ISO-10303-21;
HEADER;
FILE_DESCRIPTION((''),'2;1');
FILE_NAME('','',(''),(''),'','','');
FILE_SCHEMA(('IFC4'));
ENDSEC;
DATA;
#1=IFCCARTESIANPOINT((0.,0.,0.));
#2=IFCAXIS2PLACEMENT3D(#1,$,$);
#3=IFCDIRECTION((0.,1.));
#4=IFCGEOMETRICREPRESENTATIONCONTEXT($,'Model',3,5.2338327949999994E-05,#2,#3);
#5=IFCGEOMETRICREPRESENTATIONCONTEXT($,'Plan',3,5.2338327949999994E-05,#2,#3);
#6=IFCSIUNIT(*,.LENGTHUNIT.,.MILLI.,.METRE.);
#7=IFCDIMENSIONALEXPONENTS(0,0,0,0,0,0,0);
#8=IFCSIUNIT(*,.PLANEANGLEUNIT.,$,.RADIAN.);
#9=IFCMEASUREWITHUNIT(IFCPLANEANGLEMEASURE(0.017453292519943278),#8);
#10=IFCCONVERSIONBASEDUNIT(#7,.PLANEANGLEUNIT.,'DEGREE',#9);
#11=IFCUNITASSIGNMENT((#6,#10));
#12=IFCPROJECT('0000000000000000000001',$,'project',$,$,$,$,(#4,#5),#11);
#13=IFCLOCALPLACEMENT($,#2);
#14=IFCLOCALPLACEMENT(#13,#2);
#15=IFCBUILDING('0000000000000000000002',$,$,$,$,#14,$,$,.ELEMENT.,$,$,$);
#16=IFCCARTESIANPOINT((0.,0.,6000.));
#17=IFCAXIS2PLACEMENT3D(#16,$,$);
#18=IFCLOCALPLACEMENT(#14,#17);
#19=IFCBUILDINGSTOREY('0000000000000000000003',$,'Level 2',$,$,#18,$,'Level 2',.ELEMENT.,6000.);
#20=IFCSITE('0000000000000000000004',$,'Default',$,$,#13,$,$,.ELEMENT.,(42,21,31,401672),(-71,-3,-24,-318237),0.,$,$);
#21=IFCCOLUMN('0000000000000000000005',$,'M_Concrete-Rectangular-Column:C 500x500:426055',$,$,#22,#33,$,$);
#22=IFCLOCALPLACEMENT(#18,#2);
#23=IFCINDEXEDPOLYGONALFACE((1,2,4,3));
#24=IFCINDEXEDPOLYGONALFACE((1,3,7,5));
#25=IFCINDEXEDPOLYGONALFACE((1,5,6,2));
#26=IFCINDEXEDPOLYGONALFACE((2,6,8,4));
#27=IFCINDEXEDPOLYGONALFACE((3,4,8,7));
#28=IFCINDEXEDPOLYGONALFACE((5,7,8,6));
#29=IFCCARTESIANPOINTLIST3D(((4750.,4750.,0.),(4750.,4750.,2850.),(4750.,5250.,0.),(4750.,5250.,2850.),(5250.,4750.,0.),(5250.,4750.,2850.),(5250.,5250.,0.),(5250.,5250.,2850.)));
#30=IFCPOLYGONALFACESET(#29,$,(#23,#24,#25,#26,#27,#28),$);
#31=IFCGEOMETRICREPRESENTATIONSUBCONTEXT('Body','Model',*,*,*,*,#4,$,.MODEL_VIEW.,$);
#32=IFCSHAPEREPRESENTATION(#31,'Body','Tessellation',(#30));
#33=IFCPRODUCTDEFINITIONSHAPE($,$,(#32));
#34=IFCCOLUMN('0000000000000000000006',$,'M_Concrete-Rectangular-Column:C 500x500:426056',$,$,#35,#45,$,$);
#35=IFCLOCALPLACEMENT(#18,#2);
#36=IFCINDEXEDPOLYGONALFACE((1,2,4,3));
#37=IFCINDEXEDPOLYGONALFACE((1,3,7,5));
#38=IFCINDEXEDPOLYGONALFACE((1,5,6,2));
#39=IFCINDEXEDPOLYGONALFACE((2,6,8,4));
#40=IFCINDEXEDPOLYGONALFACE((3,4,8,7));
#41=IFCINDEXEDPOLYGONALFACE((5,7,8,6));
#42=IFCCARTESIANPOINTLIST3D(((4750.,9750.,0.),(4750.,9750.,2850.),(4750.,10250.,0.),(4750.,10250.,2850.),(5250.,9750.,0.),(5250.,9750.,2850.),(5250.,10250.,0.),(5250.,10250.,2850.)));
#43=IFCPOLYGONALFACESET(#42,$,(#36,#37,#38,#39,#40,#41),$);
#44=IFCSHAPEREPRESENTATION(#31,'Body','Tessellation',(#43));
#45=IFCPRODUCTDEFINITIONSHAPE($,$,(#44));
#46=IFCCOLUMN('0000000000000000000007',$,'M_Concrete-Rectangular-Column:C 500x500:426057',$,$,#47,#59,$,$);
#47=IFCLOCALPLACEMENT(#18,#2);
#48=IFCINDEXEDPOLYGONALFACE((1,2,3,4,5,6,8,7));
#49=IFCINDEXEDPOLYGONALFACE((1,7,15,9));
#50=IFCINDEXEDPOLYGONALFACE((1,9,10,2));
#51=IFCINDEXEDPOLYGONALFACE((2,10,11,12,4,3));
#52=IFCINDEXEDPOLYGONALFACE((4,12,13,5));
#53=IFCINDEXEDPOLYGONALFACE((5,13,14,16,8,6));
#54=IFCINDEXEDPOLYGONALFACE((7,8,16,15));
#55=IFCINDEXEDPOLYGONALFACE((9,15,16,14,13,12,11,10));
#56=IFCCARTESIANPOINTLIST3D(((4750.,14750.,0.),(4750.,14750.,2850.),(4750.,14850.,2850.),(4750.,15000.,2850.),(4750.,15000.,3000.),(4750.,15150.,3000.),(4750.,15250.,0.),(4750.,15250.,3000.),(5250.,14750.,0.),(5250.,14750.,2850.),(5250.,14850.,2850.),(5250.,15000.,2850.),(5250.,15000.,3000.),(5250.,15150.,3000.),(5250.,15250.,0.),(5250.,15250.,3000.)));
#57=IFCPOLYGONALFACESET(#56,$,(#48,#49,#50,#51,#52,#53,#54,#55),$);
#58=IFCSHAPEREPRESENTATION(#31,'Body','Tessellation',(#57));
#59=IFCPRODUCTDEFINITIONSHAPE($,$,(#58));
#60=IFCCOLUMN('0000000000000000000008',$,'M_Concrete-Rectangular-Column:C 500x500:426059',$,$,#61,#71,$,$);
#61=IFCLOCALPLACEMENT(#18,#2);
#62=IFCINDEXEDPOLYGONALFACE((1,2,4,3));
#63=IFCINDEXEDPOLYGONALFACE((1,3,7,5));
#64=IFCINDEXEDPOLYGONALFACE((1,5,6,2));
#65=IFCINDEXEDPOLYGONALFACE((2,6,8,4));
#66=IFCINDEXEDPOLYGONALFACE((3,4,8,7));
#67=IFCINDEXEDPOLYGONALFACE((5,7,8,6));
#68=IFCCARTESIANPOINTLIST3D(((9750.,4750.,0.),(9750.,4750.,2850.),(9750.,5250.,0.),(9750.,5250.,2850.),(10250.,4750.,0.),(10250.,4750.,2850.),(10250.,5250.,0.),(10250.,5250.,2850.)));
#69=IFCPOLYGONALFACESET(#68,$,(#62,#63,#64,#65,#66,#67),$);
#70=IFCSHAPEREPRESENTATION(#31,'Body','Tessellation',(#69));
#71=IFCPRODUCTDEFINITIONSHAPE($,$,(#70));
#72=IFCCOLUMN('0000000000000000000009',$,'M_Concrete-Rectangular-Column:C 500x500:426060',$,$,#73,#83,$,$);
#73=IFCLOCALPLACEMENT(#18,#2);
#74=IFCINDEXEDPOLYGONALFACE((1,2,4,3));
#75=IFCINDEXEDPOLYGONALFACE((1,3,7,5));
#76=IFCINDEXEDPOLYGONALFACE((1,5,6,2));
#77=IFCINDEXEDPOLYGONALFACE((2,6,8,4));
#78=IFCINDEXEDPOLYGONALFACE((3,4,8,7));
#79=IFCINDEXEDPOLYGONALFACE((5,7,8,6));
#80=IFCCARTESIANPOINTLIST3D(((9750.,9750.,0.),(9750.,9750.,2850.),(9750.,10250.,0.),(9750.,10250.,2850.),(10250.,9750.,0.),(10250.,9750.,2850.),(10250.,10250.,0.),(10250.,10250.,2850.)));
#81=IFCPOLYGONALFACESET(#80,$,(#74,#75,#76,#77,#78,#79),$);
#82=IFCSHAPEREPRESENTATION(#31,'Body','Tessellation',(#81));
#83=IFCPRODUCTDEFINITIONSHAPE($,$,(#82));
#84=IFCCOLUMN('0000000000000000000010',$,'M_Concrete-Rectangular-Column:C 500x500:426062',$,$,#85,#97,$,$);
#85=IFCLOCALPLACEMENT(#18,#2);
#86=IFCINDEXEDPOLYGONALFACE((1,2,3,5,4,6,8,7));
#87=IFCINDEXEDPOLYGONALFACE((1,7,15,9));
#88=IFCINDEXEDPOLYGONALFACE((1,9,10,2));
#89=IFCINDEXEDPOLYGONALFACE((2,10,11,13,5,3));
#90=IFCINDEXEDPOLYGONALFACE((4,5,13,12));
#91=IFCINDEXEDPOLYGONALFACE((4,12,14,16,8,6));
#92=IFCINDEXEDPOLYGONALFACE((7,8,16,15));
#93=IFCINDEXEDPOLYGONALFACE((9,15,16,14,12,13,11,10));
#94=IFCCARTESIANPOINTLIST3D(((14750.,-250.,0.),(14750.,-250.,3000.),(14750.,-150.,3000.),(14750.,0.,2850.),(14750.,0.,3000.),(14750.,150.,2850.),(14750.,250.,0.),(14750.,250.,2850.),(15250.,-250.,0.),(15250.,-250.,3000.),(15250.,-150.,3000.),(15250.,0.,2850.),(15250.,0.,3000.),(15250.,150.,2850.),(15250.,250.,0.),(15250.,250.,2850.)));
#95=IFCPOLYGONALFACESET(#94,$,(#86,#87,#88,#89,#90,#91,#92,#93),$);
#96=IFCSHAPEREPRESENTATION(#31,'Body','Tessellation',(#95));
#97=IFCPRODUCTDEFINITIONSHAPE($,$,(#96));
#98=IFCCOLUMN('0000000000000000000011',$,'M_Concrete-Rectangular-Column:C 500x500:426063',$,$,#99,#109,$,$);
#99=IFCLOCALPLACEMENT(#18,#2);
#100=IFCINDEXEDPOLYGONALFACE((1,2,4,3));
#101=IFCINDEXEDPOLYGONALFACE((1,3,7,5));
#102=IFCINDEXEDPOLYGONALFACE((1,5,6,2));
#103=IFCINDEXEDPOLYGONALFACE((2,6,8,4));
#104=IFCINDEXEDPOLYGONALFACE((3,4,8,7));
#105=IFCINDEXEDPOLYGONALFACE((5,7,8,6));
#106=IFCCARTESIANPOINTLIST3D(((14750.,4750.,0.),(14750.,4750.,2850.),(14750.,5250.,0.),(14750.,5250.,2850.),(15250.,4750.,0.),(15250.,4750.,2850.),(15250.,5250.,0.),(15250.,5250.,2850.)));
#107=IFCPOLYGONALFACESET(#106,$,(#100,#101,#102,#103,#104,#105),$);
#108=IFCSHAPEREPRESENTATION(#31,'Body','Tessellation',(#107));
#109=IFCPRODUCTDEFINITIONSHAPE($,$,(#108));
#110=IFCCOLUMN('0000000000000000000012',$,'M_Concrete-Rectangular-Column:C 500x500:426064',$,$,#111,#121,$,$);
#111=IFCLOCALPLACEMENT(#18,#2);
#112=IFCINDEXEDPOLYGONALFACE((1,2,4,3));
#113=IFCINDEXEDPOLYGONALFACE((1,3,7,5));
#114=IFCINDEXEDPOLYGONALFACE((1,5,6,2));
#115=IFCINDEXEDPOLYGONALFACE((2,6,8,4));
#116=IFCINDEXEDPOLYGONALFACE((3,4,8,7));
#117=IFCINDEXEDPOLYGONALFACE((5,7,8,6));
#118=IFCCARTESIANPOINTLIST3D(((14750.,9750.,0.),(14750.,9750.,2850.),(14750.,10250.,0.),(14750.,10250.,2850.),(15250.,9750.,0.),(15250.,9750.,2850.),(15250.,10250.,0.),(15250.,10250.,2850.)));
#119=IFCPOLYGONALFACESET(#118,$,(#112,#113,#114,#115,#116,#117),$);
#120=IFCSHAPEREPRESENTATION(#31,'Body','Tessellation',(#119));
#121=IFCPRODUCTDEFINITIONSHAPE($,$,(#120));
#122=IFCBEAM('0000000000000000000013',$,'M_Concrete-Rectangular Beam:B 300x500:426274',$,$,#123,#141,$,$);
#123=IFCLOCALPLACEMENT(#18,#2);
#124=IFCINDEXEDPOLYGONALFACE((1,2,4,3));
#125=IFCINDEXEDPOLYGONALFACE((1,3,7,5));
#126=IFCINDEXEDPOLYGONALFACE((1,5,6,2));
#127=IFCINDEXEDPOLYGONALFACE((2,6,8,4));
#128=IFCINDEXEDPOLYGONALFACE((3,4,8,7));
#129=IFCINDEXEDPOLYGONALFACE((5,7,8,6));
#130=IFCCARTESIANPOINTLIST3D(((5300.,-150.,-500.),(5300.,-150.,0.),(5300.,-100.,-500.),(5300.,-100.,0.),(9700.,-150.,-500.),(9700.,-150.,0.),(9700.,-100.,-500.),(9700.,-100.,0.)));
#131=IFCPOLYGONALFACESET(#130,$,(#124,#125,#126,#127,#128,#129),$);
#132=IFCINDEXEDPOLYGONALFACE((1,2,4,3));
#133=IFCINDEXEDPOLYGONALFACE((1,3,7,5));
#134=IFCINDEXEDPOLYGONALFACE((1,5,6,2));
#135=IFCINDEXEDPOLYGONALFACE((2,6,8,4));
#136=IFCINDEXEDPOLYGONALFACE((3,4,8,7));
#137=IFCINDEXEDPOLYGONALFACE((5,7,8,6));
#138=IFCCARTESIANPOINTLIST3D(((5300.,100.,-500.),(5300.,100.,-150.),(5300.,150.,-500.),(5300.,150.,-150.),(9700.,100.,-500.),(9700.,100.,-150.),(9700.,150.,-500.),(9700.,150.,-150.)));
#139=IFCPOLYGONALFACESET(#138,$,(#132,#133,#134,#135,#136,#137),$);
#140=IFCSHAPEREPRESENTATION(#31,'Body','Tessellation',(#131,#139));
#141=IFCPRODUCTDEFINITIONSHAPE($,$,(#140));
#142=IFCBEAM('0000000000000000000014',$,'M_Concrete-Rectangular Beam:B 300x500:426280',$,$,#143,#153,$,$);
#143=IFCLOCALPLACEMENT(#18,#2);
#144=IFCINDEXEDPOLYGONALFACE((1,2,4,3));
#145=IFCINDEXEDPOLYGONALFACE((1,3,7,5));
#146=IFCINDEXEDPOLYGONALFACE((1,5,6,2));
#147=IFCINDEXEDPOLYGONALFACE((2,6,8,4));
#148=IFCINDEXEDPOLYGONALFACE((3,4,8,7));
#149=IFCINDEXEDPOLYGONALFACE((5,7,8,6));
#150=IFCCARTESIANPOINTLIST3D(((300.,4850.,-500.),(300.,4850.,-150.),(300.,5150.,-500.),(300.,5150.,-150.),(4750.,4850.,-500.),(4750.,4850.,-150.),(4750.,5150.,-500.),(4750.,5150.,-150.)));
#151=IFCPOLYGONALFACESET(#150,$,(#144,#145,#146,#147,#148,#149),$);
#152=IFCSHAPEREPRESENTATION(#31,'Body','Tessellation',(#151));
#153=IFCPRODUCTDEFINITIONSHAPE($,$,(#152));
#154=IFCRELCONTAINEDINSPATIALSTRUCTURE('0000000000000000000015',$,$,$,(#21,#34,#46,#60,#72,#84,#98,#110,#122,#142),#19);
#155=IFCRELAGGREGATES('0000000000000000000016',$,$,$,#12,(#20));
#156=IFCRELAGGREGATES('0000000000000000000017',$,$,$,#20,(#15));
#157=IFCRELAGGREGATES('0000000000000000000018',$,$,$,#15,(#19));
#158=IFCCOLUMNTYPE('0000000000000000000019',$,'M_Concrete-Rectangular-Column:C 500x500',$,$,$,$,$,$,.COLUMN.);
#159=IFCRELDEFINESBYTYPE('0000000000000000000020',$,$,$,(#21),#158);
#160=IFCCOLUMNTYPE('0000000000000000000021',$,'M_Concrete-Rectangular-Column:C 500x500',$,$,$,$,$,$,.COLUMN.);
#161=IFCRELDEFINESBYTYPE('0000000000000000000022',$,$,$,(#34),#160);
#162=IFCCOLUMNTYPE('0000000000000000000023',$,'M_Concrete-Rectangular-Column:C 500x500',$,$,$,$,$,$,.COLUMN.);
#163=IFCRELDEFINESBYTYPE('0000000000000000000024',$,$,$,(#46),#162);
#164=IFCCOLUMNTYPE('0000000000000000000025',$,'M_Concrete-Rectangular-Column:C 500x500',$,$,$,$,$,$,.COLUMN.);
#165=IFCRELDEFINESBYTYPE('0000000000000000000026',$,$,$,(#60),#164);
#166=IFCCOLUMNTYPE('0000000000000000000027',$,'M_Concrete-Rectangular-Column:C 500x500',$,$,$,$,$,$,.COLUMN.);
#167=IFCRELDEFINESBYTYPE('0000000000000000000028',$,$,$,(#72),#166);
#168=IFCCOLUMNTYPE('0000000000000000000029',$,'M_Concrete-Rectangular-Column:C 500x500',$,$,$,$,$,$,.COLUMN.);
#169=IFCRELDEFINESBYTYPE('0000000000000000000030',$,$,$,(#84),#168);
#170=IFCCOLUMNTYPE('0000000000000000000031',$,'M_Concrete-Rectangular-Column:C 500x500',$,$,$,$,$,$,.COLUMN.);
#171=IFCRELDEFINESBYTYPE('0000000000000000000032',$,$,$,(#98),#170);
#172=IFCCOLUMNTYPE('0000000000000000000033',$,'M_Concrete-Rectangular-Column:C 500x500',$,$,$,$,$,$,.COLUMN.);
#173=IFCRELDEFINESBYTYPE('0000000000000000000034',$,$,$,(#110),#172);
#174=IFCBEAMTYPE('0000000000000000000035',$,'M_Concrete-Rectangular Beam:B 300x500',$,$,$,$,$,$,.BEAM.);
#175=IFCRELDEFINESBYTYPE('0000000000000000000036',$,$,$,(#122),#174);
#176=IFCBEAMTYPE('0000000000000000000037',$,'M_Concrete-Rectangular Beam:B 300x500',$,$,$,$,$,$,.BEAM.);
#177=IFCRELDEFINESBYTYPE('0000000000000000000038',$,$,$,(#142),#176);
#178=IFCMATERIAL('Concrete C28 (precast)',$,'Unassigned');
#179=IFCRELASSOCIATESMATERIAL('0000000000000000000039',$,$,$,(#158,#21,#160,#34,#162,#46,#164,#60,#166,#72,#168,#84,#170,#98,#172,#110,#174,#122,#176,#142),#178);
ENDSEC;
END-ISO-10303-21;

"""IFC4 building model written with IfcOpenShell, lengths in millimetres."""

from ifc_helpers import new_model, entity, si_unit, converted_unit, direction, frame, origin, place, context, subcontext, project, spatial, indexed_curve, outline, extrude, source, transform, mapped, material, type_object, type_shapes, element, save


model = new_model("IFC4")

# Units and contexts
model_context = context("Model", 3, precision=5.2338327949999994e-05, world=origin(), true_north=direction((0.0, 1.0)))
plan_context = context("Plan", 3, precision=5.2338327949999994e-05, world=origin(), true_north=direction((0.0, 1.0)))
body_context = subcontext(model_context, "Body", "Model", "MODEL_VIEW")
ifc_project = project(units=[si_unit("LENGTHUNIT", "METRE", prefix="MILLI"), converted_unit("PLANEANGLEUNIT", "DEGREE", entity("IfcPlaneAngleMeasure", 0.017453292519943278), si_unit("PLANEANGLEUNIT", "RADIAN"), dimensions=[0, 0, 0, 0, 0, 0, 0])], contexts=[model_context, plan_context])

# Site, building, storey
site_placement = place(None, origin())
site = spatial("IfcSite", under=ifc_project, at=site_placement, Name="Default", CompositionType="ELEMENT", RefLatitude=(42, 21, 31, 401672), RefLongitude=(-71, -3, -24, -318237), RefElevation=0.0)
building_placement = place(site_placement, origin())
building = spatial("IfcBuilding", under=site, at=building_placement, CompositionType="ELEMENT")
storey_placement = place(building_placement, frame((0.0, 0.0, 6000.0)))
storey = spatial("IfcBuildingStorey", under=building, at=storey_placement, Name="Level 2", LongName="Level 2", CompositionType="ELEMENT", Elevation=6000.0)

# Columns
ifc_material = material(Name="Concrete C28 (precast)", Category="Unassigned")
column_type_1 = type_object("IfcColumnType", Name="M_Concrete-Rectangular-Column:C 500x500", PredefinedType="COLUMN", material=ifc_material)
shared_shape_1 = source(origin(), body_context, "Body", "SweptSolid", [
    extrude(outline(indexed_curve([(-250.0, -250.0), (250.0, -250.0), (250.0, 250.0), (-250.0, 250.0), (-250.0, -250.0)], self_intersect=False)), frame((5000.0, 5000.0, 6000.0), z_axis=(0.0, 0.0, 1.0), x_axis=(-1.0, 0.0, 0.0)), (0.0, 0.0, 1.0), 2850.0),
])
type_shapes(column_type_1, [shared_shape_1])
column_1_placement = place(storey_placement, frame((0.0, 0.0, -6000.0)))
element("IfcColumn", 1, at=column_1_placement, inside=storey, type_object=column_type_1, material=ifc_material, Name="M_Concrete-Rectangular-Column:C 500x500:426055", context=body_context, shape_type="MappedRepresentation", body=[
    mapped(shared_shape_1, transform((0.0, 0.0, 0.0), scale=1.0)),
])
column_type_2 = type_object("IfcColumnType", Name="M_Concrete-Rectangular-Column:C 500x500", PredefinedType="COLUMN", material=ifc_material)
shared_shape_2 = source(origin(), body_context, "Body", "SweptSolid", [
    extrude(outline(indexed_curve([(-250.0, -250.0), (250.0, -250.0), (250.0, 250.0), (-250.0, 250.0), (-250.0, -250.0)], self_intersect=False)), frame((5000.0, 10000.0, 6000.0), z_axis=(0.0, 0.0, 1.0), x_axis=(-1.0, 0.0, 0.0)), (0.0, 0.0, 1.0), 2850.0),
])
type_shapes(column_type_2, [shared_shape_2])
column_2_placement = place(storey_placement, frame((0.0, 0.0, -6000.0)))
element("IfcColumn", 2, at=column_2_placement, inside=storey, type_object=column_type_2, material=ifc_material, Name="M_Concrete-Rectangular-Column:C 500x500:426056", context=body_context, shape_type="MappedRepresentation", body=[
    mapped(shared_shape_2, transform((0.0, 0.0, 0.0), scale=1.0)),
])
column_type_3 = type_object("IfcColumnType", Name="M_Concrete-Rectangular-Column:C 500x500", PredefinedType="COLUMN", material=ifc_material)
shared_shape_3 = source(origin(), body_context, "Body", "SweptSolid", [
    extrude(outline(indexed_curve([(-2193.7, -250.0), (806.2, -250.0), (806.2, -150.0), (806.2, 0.0), (656.3, 0.0), (656.3, 150.0), (656.3, 250.0), (-2193.7, 250.0), (-2193.7, -250.0)], self_intersect=False)), frame((4750.0, 15000.0, 8193.7), z_axis=(1.0, 0.0, 0.0), x_axis=(0.0, 0.0, 1.0)), (0.0, 0.0, 1.0), 500.0),
])
type_shapes(column_type_3, [shared_shape_3])
column_3_placement = place(storey_placement, frame((0.0, 0.0, -6000.0)))
element("IfcColumn", 3, at=column_3_placement, inside=storey, type_object=column_type_3, material=ifc_material, Name="M_Concrete-Rectangular-Column:C 500x500:426057", context=body_context, shape_type="MappedRepresentation", body=[
    mapped(shared_shape_3, transform((0.0, 0.0, 0.0), scale=1.0)),
])
column_type_4 = type_object("IfcColumnType", Name="M_Concrete-Rectangular-Column:C 500x500", PredefinedType="COLUMN", material=ifc_material)
shared_shape_4 = source(origin(), body_context, "Body", "SweptSolid", [
    extrude(outline(indexed_curve([(-250.0, -250.0), (250.0, -250.0), (250.0, 250.0), (-250.0, 250.0), (-250.0, -250.0)], self_intersect=False)), frame((10000.0, 5000.0, 6000.0), z_axis=(0.0, 0.0, 1.0), x_axis=(-1.0, 0.0, 0.0)), (0.0, 0.0, 1.0), 2850.0),
])
type_shapes(column_type_4, [shared_shape_4])
column_4_placement = place(storey_placement, frame((0.0, 0.0, -6000.0)))
element("IfcColumn", 4, at=column_4_placement, inside=storey, type_object=column_type_4, material=ifc_material, Name="M_Concrete-Rectangular-Column:C 500x500:426059", context=body_context, shape_type="MappedRepresentation", body=[
    mapped(shared_shape_4, transform((0.0, 0.0, 0.0), scale=1.0)),
])
column_type_5 = type_object("IfcColumnType", Name="M_Concrete-Rectangular-Column:C 500x500", PredefinedType="COLUMN", material=ifc_material)
shared_shape_5 = source(origin(), body_context, "Body", "SweptSolid", [
    extrude(outline(indexed_curve([(-250.0, -250.0), (250.0, -250.0), (250.0, 250.0), (-250.0, 250.0), (-250.0, -250.0)], self_intersect=False)), frame((10000.0, 10000.0, 6000.0), z_axis=(0.0, 0.0, 1.0), x_axis=(-1.0, 0.0, 0.0)), (0.0, 0.0, 1.0), 2850.0),
])
type_shapes(column_type_5, [shared_shape_5])
column_5_placement = place(storey_placement, frame((0.0, 0.0, -6000.0)))
element("IfcColumn", 5, at=column_5_placement, inside=storey, type_object=column_type_5, material=ifc_material, Name="M_Concrete-Rectangular-Column:C 500x500:426060", context=body_context, shape_type="MappedRepresentation", body=[
    mapped(shared_shape_5, transform((0.0, 0.0, 0.0), scale=1.0)),
])
column_type_6 = type_object("IfcColumnType", Name="M_Concrete-Rectangular-Column:C 500x500", PredefinedType="COLUMN", material=ifc_material)
shared_shape_6 = source(origin(), body_context, "Body", "SweptSolid", [
    extrude(outline(indexed_curve([(-2193.7, -250.0), (656.3, -250.0), (656.3, -150.0), (656.3, 0.0), (806.2, 0.0), (806.2, 150.0), (806.2, 250.0), (-2193.7, 250.0), (-2193.7, -250.0)], self_intersect=False)), frame((14750.0, 0.0, 8193.7), z_axis=(1.0, 0.0, 0.0), x_axis=(0.0, 0.0, 1.0)), (0.0, 0.0, 1.0), 500.0),
])
type_shapes(column_type_6, [shared_shape_6])
column_6_placement = place(storey_placement, frame((0.0, 0.0, -6000.0)))
element("IfcColumn", 6, at=column_6_placement, inside=storey, type_object=column_type_6, material=ifc_material, Name="M_Concrete-Rectangular-Column:C 500x500:426062", context=body_context, shape_type="MappedRepresentation", body=[
    mapped(shared_shape_6, transform((0.0, 0.0, 0.0), scale=1.0)),
])
column_type_7 = type_object("IfcColumnType", Name="M_Concrete-Rectangular-Column:C 500x500", PredefinedType="COLUMN", material=ifc_material)
shared_shape_7 = source(origin(), body_context, "Body", "SweptSolid", [
    extrude(outline(indexed_curve([(-250.0, -250.0), (250.0, -250.0), (250.0, 250.0), (-250.0, 250.0), (-250.0, -250.0)], self_intersect=False)), frame((15000.0, 5000.0, 6000.0), z_axis=(0.0, 0.0, 1.0), x_axis=(-1.0, 0.0, 0.0)), (0.0, 0.0, 1.0), 2850.0),
])
type_shapes(column_type_7, [shared_shape_7])
column_7_placement = place(storey_placement, frame((0.0, 0.0, -6000.0)))
element("IfcColumn", 7, at=column_7_placement, inside=storey, type_object=column_type_7, material=ifc_material, Name="M_Concrete-Rectangular-Column:C 500x500:426063", context=body_context, shape_type="MappedRepresentation", body=[
    mapped(shared_shape_7, transform((0.0, 0.0, 0.0), scale=1.0)),
])
column_type_8 = type_object("IfcColumnType", Name="M_Concrete-Rectangular-Column:C 500x500", PredefinedType="COLUMN", material=ifc_material)
shared_shape_8 = source(origin(), body_context, "Body", "SweptSolid", [
    extrude(outline(indexed_curve([(-250.0, -250.0), (250.0, -250.0), (250.0, 250.0), (-250.0, 250.0), (-250.0, -250.0)], self_intersect=False)), frame((15000.0, 10000.0, 6000.0), z_axis=(0.0, 0.0, 1.0), x_axis=(-1.0, 0.0, 0.0)), (0.0, 0.0, 1.0), 2850.0),
])
type_shapes(column_type_8, [shared_shape_8])
column_8_placement = place(storey_placement, frame((0.0, 0.0, -6000.0)))
element("IfcColumn", 8, at=column_8_placement, inside=storey, type_object=column_type_8, material=ifc_material, Name="M_Concrete-Rectangular-Column:C 500x500:426064", context=body_context, shape_type="MappedRepresentation", body=[
    mapped(shared_shape_8, transform((0.0, 0.0, 0.0), scale=1.0)),
])

# Beams
beam_type_1 = type_object("IfcBeamType", Name="M_Concrete-Rectangular Beam:B 300x500", PredefinedType="BEAM", material=ifc_material)
shared_shape_9 = source(origin(), body_context, "Body", "SweptSolid", [
    extrude(outline(indexed_curve([(-250.0, -25.0), (250.0, -25.0), (250.0, 25.0), (-250.0, 25.0), (-250.0, -25.0)], self_intersect=False)), frame((5300.0, -125.0, 5750.0), z_axis=(1.0, 0.0, 0.0), x_axis=(0.0, 0.0, -1.0)), (0.0, 0.0, 1.0), 4400.0),
    extrude(outline(indexed_curve([(-175.0, -25.0), (175.0, -25.0), (175.0, 25.0), (-175.0, 25.0), (-175.0, -25.0)], self_intersect=False)), frame((5300.0, 125.0, 5675.0), z_axis=(1.0, 0.0, 0.0), x_axis=(0.0, 0.0, -1.0)), (0.0, 0.0, 1.0), 4400.0),
])
type_shapes(beam_type_1, [shared_shape_9])
beam_1_placement = place(storey_placement, frame((0.0, 0.0, -6000.0)))
element("IfcBeam", 9, at=beam_1_placement, inside=storey, type_object=beam_type_1, material=ifc_material, Name="M_Concrete-Rectangular Beam:B 300x500:426274", context=body_context, shape_type="MappedRepresentation", body=[
    mapped(shared_shape_9, transform((0.0, 0.0, 0.0), scale=1.0)),
])
beam_type_2 = type_object("IfcBeamType", Name="M_Concrete-Rectangular Beam:B 300x500", PredefinedType="BEAM", material=ifc_material)
shared_shape_10 = source(origin(), body_context, "Body", "SweptSolid", [
    extrude(outline(indexed_curve([(-175.0, -150.0), (175.0, -150.0), (175.0, 150.0), (-175.0, 150.0), (-175.0, -150.0)], self_intersect=False)), frame((300.0, 5000.0, 5675.0), z_axis=(1.0, 0.0, 0.0), x_axis=(0.0, 0.0, -1.0)), (0.0, 0.0, 1.0), 4450.0),
])
type_shapes(beam_type_2, [shared_shape_10])
beam_2_placement = place(storey_placement, frame((0.0, 0.0, -6000.0)))
element("IfcBeam", 10, at=beam_2_placement, inside=storey, type_object=beam_type_2, material=ifc_material, Name="M_Concrete-Rectangular Beam:B 300x500:426280", context=body_context, shape_type="MappedRepresentation", body=[
    mapped(shared_shape_10, transform((0.0, 0.0, 0.0), scale=1.0)),
])

save(model, "model.ifc")
